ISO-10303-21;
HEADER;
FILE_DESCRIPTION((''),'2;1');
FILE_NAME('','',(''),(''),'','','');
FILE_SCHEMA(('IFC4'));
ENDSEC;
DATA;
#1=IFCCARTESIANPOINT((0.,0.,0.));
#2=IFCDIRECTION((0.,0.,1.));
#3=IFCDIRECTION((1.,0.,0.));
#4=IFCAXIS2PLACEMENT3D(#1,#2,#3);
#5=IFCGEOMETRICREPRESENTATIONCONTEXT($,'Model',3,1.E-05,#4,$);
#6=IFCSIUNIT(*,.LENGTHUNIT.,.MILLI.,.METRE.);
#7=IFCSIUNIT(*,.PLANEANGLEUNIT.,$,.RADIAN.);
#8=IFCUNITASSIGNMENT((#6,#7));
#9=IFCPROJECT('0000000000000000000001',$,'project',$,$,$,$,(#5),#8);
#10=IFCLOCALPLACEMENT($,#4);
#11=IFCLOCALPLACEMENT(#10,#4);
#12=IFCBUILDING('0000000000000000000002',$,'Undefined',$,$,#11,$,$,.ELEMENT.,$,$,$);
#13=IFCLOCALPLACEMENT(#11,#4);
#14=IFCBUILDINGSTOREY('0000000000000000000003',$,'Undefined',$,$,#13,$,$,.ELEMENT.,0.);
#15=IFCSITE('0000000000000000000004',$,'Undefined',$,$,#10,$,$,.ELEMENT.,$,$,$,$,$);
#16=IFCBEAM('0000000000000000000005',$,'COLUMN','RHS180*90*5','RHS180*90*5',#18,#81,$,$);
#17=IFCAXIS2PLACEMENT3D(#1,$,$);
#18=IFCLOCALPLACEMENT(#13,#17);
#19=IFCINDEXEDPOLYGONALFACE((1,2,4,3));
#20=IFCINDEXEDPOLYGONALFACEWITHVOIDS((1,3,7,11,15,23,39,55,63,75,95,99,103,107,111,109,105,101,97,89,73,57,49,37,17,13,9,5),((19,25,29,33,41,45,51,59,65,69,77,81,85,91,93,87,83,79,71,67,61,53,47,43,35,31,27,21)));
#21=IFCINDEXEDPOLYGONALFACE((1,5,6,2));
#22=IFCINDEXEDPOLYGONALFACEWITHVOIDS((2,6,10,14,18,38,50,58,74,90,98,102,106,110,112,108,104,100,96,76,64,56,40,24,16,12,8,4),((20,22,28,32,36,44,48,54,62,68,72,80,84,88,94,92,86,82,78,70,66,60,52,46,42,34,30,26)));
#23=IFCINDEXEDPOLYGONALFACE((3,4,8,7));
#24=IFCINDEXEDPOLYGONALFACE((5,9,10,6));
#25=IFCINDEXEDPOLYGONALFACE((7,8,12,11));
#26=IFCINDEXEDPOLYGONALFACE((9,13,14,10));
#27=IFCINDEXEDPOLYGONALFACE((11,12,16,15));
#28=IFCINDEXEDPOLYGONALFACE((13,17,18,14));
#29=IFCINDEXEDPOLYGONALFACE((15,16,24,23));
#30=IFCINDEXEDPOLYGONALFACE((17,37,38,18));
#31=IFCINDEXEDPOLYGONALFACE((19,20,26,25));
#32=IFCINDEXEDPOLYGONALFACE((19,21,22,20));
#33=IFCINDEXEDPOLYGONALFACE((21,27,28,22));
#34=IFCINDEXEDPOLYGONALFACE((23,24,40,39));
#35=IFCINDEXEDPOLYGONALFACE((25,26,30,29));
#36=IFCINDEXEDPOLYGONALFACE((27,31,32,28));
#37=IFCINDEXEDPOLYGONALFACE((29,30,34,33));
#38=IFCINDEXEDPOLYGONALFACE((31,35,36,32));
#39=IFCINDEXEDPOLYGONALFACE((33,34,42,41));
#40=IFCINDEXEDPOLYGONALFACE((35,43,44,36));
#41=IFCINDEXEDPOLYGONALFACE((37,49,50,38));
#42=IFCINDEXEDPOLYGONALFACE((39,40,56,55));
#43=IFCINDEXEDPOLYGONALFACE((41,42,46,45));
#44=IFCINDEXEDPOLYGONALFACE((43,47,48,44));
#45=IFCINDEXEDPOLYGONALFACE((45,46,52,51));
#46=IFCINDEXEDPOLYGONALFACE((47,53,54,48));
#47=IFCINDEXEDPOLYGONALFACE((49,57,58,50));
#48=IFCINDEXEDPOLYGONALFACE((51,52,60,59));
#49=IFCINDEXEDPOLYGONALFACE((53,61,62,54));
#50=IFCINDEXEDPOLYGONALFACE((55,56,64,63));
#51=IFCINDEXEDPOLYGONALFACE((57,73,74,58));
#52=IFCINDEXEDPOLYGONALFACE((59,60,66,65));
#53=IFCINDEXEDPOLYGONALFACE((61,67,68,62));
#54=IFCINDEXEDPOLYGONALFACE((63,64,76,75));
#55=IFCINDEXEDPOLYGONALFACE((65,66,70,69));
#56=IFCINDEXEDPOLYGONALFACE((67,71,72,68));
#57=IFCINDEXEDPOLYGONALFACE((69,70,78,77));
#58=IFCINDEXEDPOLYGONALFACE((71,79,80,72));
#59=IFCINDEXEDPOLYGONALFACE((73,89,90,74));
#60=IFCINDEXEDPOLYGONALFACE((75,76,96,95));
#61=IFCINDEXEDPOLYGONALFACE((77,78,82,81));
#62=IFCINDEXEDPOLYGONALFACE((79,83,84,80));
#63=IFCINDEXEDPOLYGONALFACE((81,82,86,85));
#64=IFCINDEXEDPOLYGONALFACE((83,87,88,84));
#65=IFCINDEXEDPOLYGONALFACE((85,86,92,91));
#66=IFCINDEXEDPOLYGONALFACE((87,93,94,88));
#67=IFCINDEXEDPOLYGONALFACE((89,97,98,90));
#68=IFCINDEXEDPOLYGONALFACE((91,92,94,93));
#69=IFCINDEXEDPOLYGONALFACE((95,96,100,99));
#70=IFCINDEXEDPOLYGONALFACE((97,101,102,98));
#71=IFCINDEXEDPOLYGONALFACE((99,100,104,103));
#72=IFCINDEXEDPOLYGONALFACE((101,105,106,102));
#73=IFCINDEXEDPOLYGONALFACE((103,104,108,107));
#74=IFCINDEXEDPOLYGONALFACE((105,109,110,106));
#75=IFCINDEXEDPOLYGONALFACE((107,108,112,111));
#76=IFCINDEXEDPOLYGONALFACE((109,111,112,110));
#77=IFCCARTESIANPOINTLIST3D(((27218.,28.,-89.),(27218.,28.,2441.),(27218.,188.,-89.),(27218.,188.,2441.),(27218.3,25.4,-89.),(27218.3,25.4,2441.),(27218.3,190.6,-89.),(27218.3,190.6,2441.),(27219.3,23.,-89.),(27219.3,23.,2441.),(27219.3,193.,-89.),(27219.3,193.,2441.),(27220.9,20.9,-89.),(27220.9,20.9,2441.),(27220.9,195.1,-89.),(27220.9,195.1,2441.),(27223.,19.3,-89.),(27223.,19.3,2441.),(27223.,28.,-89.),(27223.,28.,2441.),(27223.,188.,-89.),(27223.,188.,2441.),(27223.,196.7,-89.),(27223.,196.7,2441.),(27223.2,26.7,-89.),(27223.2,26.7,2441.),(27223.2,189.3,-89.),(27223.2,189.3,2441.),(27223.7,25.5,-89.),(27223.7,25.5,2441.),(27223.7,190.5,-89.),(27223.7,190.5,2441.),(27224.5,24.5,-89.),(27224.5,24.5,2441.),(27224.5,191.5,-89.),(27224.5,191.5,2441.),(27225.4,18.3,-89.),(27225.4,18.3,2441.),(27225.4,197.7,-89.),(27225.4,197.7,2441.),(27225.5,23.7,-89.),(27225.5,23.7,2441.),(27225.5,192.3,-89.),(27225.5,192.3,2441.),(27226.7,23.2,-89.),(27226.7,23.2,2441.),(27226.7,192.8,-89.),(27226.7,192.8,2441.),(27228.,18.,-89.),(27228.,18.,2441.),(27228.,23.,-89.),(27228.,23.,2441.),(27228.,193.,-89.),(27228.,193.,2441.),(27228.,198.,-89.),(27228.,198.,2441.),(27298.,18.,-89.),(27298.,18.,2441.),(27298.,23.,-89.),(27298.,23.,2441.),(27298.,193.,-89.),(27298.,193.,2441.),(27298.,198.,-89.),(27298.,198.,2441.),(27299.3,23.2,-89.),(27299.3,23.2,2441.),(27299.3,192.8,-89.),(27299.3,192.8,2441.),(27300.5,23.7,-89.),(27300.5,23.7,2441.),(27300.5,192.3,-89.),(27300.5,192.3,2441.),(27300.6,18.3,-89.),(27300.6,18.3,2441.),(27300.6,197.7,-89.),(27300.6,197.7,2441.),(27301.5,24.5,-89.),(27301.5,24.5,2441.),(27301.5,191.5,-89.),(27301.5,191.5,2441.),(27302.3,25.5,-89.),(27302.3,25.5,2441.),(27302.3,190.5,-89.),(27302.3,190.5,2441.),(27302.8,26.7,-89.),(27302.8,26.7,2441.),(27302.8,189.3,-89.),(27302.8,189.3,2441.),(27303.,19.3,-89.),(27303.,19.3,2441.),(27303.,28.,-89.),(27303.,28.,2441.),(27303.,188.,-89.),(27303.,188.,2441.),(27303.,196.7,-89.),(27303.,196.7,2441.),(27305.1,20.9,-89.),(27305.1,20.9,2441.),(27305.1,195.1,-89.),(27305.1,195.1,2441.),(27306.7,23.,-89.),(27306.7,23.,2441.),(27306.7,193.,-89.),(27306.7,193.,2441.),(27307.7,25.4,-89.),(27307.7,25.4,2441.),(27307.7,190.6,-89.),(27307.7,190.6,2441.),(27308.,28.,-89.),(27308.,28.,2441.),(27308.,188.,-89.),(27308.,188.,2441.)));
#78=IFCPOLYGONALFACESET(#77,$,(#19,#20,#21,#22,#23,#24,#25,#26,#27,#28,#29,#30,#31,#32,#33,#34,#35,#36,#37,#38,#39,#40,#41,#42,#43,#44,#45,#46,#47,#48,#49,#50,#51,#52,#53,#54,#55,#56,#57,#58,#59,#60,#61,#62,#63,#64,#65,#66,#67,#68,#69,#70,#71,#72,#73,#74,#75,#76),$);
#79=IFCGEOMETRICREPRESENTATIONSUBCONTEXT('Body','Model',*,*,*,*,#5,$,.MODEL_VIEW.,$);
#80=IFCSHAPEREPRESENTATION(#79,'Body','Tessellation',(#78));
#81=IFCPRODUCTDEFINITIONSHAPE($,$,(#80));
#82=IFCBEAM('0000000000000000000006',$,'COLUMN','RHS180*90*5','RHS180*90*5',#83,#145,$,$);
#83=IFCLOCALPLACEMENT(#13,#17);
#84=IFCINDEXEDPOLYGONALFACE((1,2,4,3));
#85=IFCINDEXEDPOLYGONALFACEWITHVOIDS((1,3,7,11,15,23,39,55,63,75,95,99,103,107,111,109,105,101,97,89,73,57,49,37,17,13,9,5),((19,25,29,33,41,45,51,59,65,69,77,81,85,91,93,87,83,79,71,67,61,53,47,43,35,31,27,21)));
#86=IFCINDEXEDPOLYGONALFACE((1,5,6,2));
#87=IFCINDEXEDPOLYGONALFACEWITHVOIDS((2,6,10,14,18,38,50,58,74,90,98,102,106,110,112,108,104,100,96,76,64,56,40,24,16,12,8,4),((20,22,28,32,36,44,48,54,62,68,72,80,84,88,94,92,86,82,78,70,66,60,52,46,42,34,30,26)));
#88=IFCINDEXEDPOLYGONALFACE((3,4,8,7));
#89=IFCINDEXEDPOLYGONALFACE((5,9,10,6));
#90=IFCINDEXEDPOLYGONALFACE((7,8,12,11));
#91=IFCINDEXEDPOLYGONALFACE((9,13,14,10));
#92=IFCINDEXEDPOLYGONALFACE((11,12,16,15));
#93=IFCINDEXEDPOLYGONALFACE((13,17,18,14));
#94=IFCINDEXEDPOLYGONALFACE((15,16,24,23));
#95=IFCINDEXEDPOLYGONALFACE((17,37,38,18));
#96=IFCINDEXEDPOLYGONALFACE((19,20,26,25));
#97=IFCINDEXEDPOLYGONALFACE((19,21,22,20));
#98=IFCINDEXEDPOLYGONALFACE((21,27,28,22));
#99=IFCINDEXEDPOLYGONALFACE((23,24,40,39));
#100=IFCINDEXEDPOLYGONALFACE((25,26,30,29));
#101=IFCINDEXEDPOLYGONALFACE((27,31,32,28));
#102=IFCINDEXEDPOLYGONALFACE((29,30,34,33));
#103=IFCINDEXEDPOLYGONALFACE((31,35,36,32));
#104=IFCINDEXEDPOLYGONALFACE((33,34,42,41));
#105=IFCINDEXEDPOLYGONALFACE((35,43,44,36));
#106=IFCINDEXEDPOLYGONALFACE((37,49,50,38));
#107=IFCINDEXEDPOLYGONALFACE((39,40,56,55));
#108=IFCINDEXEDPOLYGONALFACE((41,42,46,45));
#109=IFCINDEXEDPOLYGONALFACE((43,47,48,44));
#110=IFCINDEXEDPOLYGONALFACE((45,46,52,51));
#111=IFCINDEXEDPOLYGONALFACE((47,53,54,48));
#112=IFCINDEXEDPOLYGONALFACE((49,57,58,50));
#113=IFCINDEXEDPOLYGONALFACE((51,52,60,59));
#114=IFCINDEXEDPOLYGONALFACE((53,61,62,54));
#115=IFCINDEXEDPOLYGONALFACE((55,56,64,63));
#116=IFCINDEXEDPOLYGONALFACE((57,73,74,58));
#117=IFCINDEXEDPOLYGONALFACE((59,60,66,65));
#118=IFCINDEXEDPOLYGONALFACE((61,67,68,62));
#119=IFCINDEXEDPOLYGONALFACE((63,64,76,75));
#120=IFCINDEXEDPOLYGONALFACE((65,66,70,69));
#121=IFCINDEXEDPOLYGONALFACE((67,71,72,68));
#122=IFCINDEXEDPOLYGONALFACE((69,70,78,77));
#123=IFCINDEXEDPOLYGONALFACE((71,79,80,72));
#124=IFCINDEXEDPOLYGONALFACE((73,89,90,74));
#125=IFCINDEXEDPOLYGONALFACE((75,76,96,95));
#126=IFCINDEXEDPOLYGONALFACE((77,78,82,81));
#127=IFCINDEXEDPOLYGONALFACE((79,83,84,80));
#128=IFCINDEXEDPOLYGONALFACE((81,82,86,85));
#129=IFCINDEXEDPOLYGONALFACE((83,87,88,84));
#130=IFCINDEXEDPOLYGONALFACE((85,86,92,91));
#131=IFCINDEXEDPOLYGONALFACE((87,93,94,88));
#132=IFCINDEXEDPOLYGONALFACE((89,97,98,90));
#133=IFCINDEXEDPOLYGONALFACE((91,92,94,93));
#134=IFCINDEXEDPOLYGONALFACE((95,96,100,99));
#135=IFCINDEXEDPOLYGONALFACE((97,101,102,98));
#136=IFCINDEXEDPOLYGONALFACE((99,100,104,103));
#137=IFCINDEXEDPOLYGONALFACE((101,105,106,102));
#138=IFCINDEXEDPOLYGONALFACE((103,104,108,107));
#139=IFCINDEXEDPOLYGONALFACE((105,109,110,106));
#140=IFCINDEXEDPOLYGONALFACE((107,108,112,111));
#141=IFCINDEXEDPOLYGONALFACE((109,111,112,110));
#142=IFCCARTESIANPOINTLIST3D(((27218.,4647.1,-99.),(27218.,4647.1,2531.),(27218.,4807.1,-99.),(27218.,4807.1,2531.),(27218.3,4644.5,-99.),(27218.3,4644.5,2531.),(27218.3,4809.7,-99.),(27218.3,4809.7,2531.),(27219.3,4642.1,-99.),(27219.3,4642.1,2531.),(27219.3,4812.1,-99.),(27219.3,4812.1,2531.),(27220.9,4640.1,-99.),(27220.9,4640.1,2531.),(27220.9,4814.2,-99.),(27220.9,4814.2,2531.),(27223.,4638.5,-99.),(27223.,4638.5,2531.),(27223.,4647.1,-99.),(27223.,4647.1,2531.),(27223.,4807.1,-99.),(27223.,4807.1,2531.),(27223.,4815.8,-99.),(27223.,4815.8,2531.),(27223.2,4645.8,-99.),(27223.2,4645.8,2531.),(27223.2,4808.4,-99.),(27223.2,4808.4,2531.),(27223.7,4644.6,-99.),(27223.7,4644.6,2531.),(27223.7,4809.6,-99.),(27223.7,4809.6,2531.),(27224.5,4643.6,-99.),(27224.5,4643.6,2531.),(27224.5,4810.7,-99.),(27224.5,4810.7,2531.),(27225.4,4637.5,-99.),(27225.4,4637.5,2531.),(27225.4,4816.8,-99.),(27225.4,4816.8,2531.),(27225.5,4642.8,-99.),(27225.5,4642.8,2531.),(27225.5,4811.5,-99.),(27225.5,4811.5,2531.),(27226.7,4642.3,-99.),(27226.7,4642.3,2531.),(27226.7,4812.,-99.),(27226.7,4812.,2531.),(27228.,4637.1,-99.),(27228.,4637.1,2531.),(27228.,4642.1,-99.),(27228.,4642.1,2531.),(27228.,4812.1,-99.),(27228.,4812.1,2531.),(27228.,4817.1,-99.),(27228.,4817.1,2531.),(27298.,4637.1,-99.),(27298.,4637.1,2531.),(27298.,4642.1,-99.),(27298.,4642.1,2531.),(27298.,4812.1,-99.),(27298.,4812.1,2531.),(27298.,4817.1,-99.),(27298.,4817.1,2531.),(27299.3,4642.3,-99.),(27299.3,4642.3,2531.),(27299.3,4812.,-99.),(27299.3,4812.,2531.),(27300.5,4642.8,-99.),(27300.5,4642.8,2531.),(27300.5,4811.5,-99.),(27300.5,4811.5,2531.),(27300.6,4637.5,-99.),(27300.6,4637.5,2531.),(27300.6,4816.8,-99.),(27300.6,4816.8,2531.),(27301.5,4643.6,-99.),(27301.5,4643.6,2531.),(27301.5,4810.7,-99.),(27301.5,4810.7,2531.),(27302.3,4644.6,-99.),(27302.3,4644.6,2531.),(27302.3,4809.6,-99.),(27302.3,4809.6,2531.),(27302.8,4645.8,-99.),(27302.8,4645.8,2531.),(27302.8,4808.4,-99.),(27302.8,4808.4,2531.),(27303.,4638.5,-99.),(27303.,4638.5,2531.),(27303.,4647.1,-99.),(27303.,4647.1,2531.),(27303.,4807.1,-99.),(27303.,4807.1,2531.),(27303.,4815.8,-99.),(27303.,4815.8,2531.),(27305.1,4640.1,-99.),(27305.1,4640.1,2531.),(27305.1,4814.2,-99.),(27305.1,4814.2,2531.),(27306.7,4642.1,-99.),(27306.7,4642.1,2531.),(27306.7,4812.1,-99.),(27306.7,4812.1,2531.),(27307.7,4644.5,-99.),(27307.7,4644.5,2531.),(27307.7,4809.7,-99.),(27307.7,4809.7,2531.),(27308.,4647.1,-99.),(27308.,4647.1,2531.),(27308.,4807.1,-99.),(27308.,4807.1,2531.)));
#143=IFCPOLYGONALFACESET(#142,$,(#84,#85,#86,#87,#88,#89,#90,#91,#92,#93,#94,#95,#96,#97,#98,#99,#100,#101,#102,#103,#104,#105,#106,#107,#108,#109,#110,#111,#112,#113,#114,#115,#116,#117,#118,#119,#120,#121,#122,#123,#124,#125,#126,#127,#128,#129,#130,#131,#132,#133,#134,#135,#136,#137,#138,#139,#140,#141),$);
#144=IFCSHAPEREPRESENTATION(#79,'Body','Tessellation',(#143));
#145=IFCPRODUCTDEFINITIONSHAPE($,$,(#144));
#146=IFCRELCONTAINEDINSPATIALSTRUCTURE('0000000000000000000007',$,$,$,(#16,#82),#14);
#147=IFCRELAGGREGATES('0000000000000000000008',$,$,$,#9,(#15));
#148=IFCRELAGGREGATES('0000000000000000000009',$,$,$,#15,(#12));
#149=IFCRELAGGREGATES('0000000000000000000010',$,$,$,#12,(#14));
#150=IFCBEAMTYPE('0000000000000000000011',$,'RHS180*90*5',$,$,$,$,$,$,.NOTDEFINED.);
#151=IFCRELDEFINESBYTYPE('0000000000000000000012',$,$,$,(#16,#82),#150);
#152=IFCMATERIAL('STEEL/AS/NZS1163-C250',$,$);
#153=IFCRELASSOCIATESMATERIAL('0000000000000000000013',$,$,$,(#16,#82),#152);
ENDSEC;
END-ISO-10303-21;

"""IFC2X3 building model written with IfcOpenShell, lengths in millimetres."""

from ifc_helpers import new_model, si_unit, frame, origin_with_axes, origin_2d_with_axis, place, context, subcontext, project, spatial, hollow_rectangle, extrude, material, type_object, element, save


model = new_model("IFC2X3")

# Units and contexts
model_context = context("Model", 3, precision=1e-05, world=origin_with_axes())
body_context = subcontext(model_context, "Body", "Model", "MODEL_VIEW")
ifc_project = project(units=[si_unit("LENGTHUNIT", "METRE", prefix="MILLI"), si_unit("PLANEANGLEUNIT", "RADIAN")], contexts=[model_context])

# Site, building, storey
site_placement = place(None, origin_with_axes())
site = spatial("IfcSite", under=ifc_project, at=site_placement, Name="Undefined", CompositionType="ELEMENT")
building_placement = place(site_placement, origin_with_axes())
building = spatial("IfcBuilding", under=site, at=building_placement, Name="Undefined", CompositionType="ELEMENT")
storey_placement = place(building_placement, origin_with_axes())
storey = spatial("IfcBuildingStorey", under=building, at=storey_placement, Name="Undefined", CompositionType="ELEMENT", Elevation=0.0)

# Shared definitions
ifc_material_1 = material(Name="STEEL/AS/NZS1163-C250")

# Beams
beam_type_1 = type_object("IfcBeamType", Name="RHS180*90*5", PredefinedType="NOTDEFINED")
beam_1_placement = place(storey_placement, frame((27263.0, 108.0, 2441.0), z_axis=(0.0, 1.0, 0.0), x_axis=(0.0, 0.0, -1.0)))
element("IfcBeam", 1, at=beam_1_placement, inside=storey, type_object=beam_type_1, material=ifc_material_1, Name="COLUMN", Description="RHS180*90*5", ObjectType="RHS180*90*5", context=body_context, shape_type="SweptSolid", body=[
    extrude(hollow_rectangle(XDim=90.0, YDim=180.0, WallThickness=5.0, InnerFilletRadius=5.0, OuterFilletRadius=10.0, at=origin_2d_with_axis()), frame((2530.0, 0.0, 0.0), z_axis=(-1.0, 0.0, 0.0), x_axis=(0.0, -1.0, 0.0)), (0.0, 0.0, 1.0), 2530.0),
])
beam_2_placement = place(storey_placement, frame((27263.0, 4727.1, 2531.0), z_axis=(0.0, 1.0, 0.0), x_axis=(0.0, 0.0, -1.0)))
element("IfcBeam", 2, at=beam_2_placement, inside=storey, type_object=beam_type_1, material=ifc_material_1, Name="COLUMN", Description="RHS180*90*5", ObjectType="RHS180*90*5", context=body_context, shape_type="SweptSolid", body=[
    extrude(hollow_rectangle(XDim=90.0, YDim=180.0, WallThickness=5.0, InnerFilletRadius=5.0, OuterFilletRadius=10.0, at=origin_2d_with_axis()), frame((2630.0, 0.0, 0.0), z_axis=(-1.0, 0.0, 0.0), x_axis=(0.0, -1.0, 0.0)), (0.0, 0.0, 1.0), 2630.0),
])

save(model, "model.ifc")
